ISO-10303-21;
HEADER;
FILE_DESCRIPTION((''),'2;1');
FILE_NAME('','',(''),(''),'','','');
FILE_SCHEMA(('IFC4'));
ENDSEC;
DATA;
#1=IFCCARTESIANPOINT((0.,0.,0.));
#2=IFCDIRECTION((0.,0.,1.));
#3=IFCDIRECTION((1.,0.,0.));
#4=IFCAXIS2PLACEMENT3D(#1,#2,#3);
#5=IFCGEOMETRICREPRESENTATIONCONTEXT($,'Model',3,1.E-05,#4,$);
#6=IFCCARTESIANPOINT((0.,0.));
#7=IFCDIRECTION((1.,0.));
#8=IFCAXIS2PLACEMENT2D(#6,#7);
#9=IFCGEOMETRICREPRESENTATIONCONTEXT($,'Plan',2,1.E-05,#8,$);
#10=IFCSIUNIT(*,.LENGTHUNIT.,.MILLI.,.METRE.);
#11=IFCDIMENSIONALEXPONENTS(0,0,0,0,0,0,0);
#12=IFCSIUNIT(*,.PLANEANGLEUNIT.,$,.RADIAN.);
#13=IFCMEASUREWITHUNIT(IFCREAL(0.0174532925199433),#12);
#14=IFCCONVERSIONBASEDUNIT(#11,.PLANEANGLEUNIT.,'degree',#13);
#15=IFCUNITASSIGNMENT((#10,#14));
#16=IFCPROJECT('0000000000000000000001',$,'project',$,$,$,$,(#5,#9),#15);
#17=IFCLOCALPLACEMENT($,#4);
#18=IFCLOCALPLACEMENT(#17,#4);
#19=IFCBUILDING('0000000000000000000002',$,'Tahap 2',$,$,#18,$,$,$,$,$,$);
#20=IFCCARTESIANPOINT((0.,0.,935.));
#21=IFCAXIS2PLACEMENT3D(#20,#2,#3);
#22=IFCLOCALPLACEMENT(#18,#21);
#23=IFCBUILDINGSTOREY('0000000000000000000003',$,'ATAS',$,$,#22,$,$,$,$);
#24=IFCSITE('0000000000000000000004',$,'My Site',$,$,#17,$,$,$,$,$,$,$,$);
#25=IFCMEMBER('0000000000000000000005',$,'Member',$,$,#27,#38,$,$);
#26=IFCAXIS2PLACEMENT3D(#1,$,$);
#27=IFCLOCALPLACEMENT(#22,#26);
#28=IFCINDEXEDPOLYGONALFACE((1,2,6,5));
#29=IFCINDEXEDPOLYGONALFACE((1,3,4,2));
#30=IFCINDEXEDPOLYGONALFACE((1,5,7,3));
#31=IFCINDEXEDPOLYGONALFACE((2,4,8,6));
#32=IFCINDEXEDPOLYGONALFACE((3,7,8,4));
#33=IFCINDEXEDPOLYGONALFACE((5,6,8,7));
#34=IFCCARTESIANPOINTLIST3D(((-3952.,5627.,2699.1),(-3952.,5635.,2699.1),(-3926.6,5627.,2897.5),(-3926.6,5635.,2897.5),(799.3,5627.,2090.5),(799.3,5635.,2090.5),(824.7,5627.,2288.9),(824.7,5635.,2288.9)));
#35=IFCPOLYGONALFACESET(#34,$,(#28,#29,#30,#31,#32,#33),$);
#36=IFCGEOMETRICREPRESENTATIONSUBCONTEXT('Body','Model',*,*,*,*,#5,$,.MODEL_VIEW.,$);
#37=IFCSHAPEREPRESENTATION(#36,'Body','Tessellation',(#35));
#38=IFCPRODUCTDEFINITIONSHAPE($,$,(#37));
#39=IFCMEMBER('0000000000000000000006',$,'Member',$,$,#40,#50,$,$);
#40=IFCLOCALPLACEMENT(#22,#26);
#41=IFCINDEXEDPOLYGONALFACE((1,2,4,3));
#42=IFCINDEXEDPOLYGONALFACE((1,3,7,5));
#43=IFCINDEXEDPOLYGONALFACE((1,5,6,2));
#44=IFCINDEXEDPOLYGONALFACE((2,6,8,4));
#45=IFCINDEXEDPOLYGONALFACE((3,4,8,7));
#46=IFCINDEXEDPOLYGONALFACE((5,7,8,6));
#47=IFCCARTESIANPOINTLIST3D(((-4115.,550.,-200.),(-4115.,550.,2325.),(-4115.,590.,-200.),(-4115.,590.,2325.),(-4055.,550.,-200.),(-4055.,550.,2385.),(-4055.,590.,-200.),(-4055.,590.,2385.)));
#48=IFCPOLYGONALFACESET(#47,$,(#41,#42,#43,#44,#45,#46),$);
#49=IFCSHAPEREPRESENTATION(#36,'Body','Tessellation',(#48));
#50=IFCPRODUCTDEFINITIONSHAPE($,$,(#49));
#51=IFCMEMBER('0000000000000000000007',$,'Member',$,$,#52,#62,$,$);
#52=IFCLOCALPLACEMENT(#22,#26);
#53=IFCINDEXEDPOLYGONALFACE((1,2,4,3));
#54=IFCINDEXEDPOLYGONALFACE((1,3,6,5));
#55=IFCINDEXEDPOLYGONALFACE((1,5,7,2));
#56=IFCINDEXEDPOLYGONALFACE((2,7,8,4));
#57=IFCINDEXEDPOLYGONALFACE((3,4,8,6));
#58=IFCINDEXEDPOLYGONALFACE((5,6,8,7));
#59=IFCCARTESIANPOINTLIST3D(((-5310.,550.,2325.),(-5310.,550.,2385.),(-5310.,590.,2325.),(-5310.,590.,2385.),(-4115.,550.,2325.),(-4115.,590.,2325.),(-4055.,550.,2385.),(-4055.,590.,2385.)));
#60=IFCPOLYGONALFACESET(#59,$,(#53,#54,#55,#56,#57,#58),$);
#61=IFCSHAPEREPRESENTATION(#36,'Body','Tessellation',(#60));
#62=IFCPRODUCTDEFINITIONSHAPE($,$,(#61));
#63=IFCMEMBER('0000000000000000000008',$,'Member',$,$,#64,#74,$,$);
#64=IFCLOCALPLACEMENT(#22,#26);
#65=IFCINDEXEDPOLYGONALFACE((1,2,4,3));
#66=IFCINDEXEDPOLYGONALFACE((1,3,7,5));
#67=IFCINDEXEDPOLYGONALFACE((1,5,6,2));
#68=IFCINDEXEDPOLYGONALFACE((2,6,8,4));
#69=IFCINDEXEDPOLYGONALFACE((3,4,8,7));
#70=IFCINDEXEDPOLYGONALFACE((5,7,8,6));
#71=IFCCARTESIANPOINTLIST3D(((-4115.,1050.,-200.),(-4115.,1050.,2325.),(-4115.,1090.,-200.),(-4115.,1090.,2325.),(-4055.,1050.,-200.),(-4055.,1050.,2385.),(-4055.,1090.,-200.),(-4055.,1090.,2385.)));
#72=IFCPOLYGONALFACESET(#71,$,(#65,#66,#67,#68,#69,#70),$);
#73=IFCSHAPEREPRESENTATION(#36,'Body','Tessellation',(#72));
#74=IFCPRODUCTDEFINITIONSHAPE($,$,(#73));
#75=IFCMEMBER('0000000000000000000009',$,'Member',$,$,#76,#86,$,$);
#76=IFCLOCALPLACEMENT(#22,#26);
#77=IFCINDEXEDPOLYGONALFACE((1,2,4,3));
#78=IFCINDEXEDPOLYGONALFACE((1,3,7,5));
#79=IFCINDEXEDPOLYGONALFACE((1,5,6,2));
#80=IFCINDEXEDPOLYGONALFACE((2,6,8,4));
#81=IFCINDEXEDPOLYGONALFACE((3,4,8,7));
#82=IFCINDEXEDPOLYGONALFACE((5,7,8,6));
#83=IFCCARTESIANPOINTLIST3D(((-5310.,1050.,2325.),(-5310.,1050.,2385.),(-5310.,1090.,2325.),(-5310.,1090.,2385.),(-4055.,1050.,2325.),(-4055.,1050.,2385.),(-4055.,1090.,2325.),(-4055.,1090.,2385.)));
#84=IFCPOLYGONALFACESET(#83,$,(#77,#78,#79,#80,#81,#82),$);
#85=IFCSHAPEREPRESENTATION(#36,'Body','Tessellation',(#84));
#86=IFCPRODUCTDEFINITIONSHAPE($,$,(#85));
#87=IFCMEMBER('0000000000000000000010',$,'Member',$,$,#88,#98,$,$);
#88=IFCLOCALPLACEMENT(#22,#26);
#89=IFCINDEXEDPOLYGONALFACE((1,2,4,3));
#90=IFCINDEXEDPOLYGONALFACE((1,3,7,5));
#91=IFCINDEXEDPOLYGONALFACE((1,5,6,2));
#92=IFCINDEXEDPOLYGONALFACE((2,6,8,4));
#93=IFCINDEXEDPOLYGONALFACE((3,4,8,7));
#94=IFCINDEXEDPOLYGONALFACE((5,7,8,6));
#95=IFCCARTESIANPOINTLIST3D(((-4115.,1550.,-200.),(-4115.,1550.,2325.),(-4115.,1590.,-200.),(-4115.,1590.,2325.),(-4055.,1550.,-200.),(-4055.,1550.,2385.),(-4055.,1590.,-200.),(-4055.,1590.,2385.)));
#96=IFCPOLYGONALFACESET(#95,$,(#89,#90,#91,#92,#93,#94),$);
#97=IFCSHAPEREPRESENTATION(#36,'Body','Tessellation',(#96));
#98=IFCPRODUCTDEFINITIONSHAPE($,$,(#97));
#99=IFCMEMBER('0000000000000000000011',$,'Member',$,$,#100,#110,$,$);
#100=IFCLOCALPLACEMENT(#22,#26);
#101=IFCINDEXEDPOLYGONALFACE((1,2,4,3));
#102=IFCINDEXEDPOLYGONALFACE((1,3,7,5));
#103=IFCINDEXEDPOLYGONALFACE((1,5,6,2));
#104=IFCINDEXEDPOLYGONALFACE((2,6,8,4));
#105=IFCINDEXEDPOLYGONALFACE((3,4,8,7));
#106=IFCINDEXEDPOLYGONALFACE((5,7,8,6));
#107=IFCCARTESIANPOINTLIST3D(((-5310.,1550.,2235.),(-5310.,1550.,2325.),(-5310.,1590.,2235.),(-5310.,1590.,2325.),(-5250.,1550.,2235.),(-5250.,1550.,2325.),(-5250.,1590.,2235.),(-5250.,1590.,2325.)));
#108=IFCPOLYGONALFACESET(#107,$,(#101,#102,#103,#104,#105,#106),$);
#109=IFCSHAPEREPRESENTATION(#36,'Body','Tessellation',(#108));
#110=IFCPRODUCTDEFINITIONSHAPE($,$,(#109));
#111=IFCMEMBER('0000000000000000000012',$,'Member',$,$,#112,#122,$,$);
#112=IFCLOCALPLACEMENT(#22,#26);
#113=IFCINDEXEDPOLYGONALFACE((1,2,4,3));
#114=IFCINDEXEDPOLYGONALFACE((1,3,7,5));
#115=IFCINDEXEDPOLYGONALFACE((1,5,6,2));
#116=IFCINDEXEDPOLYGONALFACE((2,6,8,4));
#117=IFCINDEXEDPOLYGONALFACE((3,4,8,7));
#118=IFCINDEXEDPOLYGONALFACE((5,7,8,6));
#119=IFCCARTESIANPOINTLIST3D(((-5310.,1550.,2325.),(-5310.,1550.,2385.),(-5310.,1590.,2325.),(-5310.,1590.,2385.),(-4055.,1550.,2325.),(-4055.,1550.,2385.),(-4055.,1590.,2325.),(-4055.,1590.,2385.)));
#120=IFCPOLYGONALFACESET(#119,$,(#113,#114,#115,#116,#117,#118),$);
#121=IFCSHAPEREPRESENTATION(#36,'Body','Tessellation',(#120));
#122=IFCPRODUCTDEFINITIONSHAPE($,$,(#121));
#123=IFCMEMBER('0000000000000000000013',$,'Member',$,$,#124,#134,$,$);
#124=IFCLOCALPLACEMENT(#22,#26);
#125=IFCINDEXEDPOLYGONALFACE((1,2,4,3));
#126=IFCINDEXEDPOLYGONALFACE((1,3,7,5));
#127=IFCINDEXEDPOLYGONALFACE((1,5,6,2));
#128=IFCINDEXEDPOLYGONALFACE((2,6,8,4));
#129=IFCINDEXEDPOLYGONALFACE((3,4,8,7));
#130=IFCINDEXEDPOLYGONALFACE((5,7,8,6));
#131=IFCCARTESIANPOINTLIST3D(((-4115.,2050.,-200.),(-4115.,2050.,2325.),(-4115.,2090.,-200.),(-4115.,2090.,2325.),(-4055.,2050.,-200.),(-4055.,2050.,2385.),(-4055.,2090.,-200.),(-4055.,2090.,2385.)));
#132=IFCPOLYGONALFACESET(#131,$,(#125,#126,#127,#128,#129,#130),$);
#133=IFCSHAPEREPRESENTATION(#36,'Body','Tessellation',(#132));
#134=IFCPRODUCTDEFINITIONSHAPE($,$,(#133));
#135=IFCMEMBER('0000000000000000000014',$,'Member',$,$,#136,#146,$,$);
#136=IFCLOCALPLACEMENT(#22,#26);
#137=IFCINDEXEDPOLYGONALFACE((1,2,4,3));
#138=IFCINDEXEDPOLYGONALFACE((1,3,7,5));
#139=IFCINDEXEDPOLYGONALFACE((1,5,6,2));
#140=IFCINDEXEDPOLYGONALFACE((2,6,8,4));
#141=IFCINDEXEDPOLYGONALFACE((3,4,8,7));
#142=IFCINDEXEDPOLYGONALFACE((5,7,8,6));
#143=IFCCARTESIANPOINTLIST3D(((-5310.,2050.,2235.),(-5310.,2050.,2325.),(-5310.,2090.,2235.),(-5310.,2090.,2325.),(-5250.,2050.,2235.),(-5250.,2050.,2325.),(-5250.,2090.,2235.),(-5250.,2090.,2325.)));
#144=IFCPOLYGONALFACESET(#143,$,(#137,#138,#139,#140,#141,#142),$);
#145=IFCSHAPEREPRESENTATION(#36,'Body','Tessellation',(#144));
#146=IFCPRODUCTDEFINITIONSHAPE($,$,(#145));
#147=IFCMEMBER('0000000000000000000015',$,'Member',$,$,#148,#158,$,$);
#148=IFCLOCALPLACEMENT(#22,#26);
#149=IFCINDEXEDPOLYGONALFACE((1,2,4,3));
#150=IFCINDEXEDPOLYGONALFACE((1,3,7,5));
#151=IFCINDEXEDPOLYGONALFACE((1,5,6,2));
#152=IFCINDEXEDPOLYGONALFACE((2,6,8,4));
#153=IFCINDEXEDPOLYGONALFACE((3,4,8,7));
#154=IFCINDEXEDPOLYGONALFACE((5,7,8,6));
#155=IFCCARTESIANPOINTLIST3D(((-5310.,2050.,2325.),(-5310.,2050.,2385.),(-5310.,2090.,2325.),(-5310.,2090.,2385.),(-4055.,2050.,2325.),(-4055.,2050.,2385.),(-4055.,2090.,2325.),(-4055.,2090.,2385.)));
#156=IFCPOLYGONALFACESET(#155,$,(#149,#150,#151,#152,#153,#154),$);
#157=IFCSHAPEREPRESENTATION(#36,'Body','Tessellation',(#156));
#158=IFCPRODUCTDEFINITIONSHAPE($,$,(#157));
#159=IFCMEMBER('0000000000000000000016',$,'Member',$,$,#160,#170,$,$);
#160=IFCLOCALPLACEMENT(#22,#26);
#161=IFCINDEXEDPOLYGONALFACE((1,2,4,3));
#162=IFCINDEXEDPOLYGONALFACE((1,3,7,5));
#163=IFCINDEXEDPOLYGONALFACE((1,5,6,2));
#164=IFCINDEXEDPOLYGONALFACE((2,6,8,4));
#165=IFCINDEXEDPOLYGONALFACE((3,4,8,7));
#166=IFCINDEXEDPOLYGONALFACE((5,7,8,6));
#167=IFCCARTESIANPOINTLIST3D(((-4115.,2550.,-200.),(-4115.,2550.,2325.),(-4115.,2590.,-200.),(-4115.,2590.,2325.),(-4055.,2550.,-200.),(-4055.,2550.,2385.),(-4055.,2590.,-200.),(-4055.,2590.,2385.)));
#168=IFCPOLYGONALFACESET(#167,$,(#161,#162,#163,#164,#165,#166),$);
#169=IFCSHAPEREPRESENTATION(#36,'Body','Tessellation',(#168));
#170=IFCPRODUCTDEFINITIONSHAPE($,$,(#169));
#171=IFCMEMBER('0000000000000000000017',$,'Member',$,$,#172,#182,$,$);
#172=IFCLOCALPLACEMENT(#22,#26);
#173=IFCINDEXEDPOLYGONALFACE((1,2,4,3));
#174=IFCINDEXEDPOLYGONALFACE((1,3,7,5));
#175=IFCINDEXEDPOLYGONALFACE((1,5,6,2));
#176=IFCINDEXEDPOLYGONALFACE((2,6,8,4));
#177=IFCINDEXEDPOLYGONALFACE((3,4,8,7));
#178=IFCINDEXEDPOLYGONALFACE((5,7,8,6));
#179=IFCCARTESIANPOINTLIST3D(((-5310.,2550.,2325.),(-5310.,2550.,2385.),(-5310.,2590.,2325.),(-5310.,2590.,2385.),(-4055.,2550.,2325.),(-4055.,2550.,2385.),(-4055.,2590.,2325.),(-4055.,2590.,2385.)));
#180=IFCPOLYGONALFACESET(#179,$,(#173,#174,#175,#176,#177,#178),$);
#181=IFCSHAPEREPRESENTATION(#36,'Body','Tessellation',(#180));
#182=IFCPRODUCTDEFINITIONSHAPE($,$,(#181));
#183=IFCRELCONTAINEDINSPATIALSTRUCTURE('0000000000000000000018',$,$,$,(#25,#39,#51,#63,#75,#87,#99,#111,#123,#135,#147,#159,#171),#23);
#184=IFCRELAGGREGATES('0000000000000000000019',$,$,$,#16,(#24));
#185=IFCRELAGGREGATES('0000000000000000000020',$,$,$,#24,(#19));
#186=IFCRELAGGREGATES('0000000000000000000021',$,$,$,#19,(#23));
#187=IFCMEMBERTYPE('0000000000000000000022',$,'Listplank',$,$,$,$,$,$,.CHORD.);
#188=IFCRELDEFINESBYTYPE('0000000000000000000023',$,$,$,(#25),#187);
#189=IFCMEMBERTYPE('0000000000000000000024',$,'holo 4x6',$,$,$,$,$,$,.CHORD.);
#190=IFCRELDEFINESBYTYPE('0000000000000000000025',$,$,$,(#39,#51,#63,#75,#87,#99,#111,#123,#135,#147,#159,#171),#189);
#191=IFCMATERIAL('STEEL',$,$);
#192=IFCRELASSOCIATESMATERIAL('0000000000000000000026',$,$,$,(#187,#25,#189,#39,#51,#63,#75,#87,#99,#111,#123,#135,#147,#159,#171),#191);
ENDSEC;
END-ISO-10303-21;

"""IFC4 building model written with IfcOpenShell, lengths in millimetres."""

from ifc_helpers import new_model, entity, si_unit, converted_unit, frame, origin_with_axes, origin_2d_with_axis, place, context, subcontext, project, spatial, rectangle, extrude, clip, halfspace, material, material_profile, profile_set, profile_usage, type_object, element, save


model = new_model("IFC4")

# Units and contexts
model_context = context("Model", 3, precision=1e-05, world=origin_with_axes())
plan_context = context("Plan", 2, precision=1e-05, world=origin_2d_with_axis())
body_context = subcontext(model_context, "Body", "Model", "MODEL_VIEW")
ifc_project = project(units=[si_unit("LENGTHUNIT", "METRE", prefix="MILLI"), converted_unit("PLANEANGLEUNIT", "degree", entity("IfcReal", 0.0174532925199433), si_unit("PLANEANGLEUNIT", "RADIAN"), dimensions=[0, 0, 0, 0, 0, 0, 0])], contexts=[model_context, plan_context])

# Site, building, storey
site_placement = place(None, origin_with_axes())
site = spatial("IfcSite", under=ifc_project, at=site_placement, Name="My Site")
building_placement = place(site_placement, origin_with_axes())
building = spatial("IfcBuilding", under=site, at=building_placement, Name="Tahap 2")
storey_placement = place(building_placement, frame((0.0, 0.0, 935.0), z_axis=(0.0, 0.0, 1.0), x_axis=(1.0, 0.0, 0.0)))
storey = spatial("IfcBuildingStorey", under=building, at=storey_placement, Name="ATAS")

# Members
ifc_material_1 = material(Name="STEEL")
ifc_material_profile_1 = material_profile(ifc_material_1, rectangle(XDim=8.0, YDim=200.0, kind="CURVE"))
ifc_profile_set_1 = profile_set([ifc_material_profile_1])
ifc_profile_usage_1 = profile_usage(ifc_profile_set_1, cardinal=9)
member_type_1 = type_object("IfcMemberType", Name="Listplank", PredefinedType="CHORD", material=ifc_profile_set_1)
member_1_placement = place(storey_placement, frame((824.7, 5635.0, 2288.9), z_axis=(-0.991894, 0.0, 0.127064), x_axis=(0.0, -1.0, 0.0)))
element("IfcMember", 1, at=member_1_placement, inside=storey, type_object=member_type_1, material=ifc_profile_usage_1, Name="Member", context=body_context, shape_type="SweptSolid", body=[
    extrude(rectangle(XDim=8.0, YDim=200.0, kind="CURVE"), frame((4.0, -100.0, 0.0), z_axis=(0.0, 0.0, 1.0), x_axis=(1.0, 0.0, 0.0)), (0.0, 0.0, 1.0), 4790.2),
])
ifc_material_profile_2 = material_profile(ifc_material_1, rectangle(XDim=40.0, YDim=60.0, kind="CURVE"))
ifc_profile_set_2 = profile_set([ifc_material_profile_2])
ifc_profile_usage_2 = profile_usage(ifc_profile_set_2, cardinal=8)
member_type_2 = type_object("IfcMemberType", Name="holo 4x6", PredefinedType="CHORD", material=ifc_profile_set_2)
member_2_placement = place(storey_placement, frame((-4055.0, 570.0, -200.0), z_axis=(0.0, 0.0, 1.0), x_axis=(0.0, -1.0, 0.0)))
element("IfcMember", 2, at=member_2_placement, inside=storey, type_object=member_type_2, material=ifc_profile_usage_2, Name="Member", context=body_context, shape_type="Clipping", body=[
    clip(extrude(rectangle(XDim=40.0, YDim=60.0, kind="CURVE"), frame((0.0, -30.0, 0.0), z_axis=(0.0, 0.0, 1.0), x_axis=(1.0, 0.0, 0.0)), (0.0, 0.0, 1.0), 2585.0), halfspace(frame((550.0, 0.0, 2585.0), z_axis=(0.0, -0.707107, 0.707107), x_axis=(-1.0, 0.0, 0.0)), False)),
])
ifc_profile_usage_3 = profile_usage(ifc_profile_set_2, cardinal=8)
member_3_placement = place(storey_placement, frame((-4055.0, 570.0, 2385.0), z_axis=(-1.0, 0.0, 0.0), x_axis=(0.0, -1.0, 0.0)))
element("IfcMember", 3, at=member_3_placement, inside=storey, type_object=member_type_2, material=ifc_profile_usage_3, Name="Member", context=body_context, shape_type="Clipping", body=[
    clip(extrude(rectangle(XDim=40.0, YDim=60.0, kind="CURVE"), frame((0.0, -30.0, 0.0), z_axis=(0.0, 0.0, 1.0), x_axis=(1.0, 0.0, 0.0)), (0.0, 0.0, 1.0), 1255.0), halfspace(frame((570.0, 0.0, 0.0), z_axis=(0.0, -0.707107, -0.707107), x_axis=(-1.0, 0.0, 0.0)), False)),
])
ifc_profile_usage_4 = profile_usage(ifc_profile_set_2, cardinal=8)
member_4_placement = place(storey_placement, frame((-4055.0, 1070.0, -200.0), z_axis=(0.0, 0.0, 1.0), x_axis=(0.0, -1.0, 0.0)))
element("IfcMember", 4, at=member_4_placement, inside=storey, type_object=member_type_2, material=ifc_profile_usage_4, Name="Member", context=body_context, shape_type="Clipping", body=[
    clip(extrude(rectangle(XDim=40.0, YDim=60.0, kind="CURVE"), frame((0.0, -30.0, 0.0), z_axis=(0.0, 0.0, 1.0), x_axis=(1.0, 0.0, 0.0)), (0.0, 0.0, 1.0), 2585.0), halfspace(frame((550.0, 0.0, 2585.0), z_axis=(0.0, -0.707107, 0.707107), x_axis=(-1.0, 0.0, 0.0)), False)),
])
ifc_profile_usage_5 = profile_usage(ifc_profile_set_2, cardinal=8)
member_5_placement = place(storey_placement, frame((-4055.0, 1070.0, 2385.0), z_axis=(-1.0, 0.0, 0.0), x_axis=(0.0, -1.0, 0.0)))
element("IfcMember", 5, at=member_5_placement, inside=storey, type_object=member_type_2, material=ifc_profile_usage_5, Name="Member", context=body_context, shape_type="SweptSolid", body=[
    extrude(rectangle(XDim=40.0, YDim=60.0, kind="CURVE"), frame((0.0, -30.0, 0.0), z_axis=(0.0, 0.0, 1.0), x_axis=(1.0, 0.0, 0.0)), (0.0, 0.0, 1.0), 1255.0),
])
ifc_profile_usage_6 = profile_usage(ifc_profile_set_2, cardinal=8)
member_6_placement = place(storey_placement, frame((-4055.0, 1570.0, -200.0), z_axis=(0.0, 0.0, 1.0), x_axis=(0.0, -1.0, 0.0)))
element("IfcMember", 6, at=member_6_placement, inside=storey, type_object=member_type_2, material=ifc_profile_usage_6, Name="Member", context=body_context, shape_type="Clipping", body=[
    clip(extrude(rectangle(XDim=40.0, YDim=60.0, kind="CURVE"), frame((0.0, -30.0, 0.0), z_axis=(0.0, 0.0, 1.0), x_axis=(1.0, 0.0, 0.0)), (0.0, 0.0, 1.0), 2585.0), halfspace(frame((550.0, 0.0, 2585.0), z_axis=(0.0, -0.707107, 0.707107), x_axis=(-1.0, 0.0, 0.0)), False)),
])
ifc_profile_usage_7 = profile_usage(ifc_profile_set_2, cardinal=8)
member_7_placement = place(storey_placement, frame((-5250.0, 1570.0, 2235.0), z_axis=(0.0, 0.0, 1.0), x_axis=(0.0, -1.0, 0.0)))
element("IfcMember", 7, at=member_7_placement, inside=storey, type_object=member_type_2, material=ifc_profile_usage_7, Name="Member", context=body_context, shape_type="SweptSolid", body=[
    extrude(rectangle(XDim=40.0, YDim=60.0, kind="CURVE"), frame((0.0, -30.0, 0.0), z_axis=(0.0, 0.0, 1.0), x_axis=(1.0, 0.0, 0.0)), (0.0, 0.0, 1.0), 90.0),
])
ifc_profile_usage_8 = profile_usage(ifc_profile_set_2, cardinal=8)
member_8_placement = place(storey_placement, frame((-4055.0, 1570.0, 2385.0), z_axis=(-1.0, 0.0, 0.0), x_axis=(0.0, -1.0, 0.0)))
element("IfcMember", 8, at=member_8_placement, inside=storey, type_object=member_type_2, material=ifc_profile_usage_8, Name="Member", context=body_context, shape_type="SweptSolid", body=[
    extrude(rectangle(XDim=40.0, YDim=60.0, kind="CURVE"), frame((0.0, -30.0, 0.0), z_axis=(0.0, 0.0, 1.0), x_axis=(1.0, 0.0, 0.0)), (0.0, 0.0, 1.0), 1255.0),
])
ifc_profile_usage_9 = profile_usage(ifc_profile_set_2, cardinal=8)
member_9_placement = place(storey_placement, frame((-4055.0, 2070.0, -200.0), z_axis=(0.0, 0.0, 1.0), x_axis=(0.0, -1.0, 0.0)))
element("IfcMember", 9, at=member_9_placement, inside=storey, type_object=member_type_2, material=ifc_profile_usage_9, Name="Member", context=body_context, shape_type="Clipping", body=[
    clip(extrude(rectangle(XDim=40.0, YDim=60.0, kind="CURVE"), frame((0.0, -30.0, 0.0), z_axis=(0.0, 0.0, 1.0), x_axis=(1.0, 0.0, 0.0)), (0.0, 0.0, 1.0), 2585.0), halfspace(frame((550.0, 0.0, 2585.0), z_axis=(0.0, -0.707107, 0.707107), x_axis=(-1.0, 0.0, 0.0)), False)),
])
ifc_profile_usage_10 = profile_usage(ifc_profile_set_2, cardinal=8)
member_10_placement = place(storey_placement, frame((-5250.0, 2070.0, 2235.0), z_axis=(0.0, 0.0, 1.0), x_axis=(0.0, -1.0, 0.0)))
element("IfcMember", 10, at=member_10_placement, inside=storey, type_object=member_type_2, material=ifc_profile_usage_10, Name="Member", context=body_context, shape_type="SweptSolid", body=[
    extrude(rectangle(XDim=40.0, YDim=60.0, kind="CURVE"), frame((0.0, -30.0, 0.0), z_axis=(0.0, 0.0, 1.0), x_axis=(1.0, 0.0, 0.0)), (0.0, 0.0, 1.0), 90.0),
])
ifc_profile_usage_11 = profile_usage(ifc_profile_set_2, cardinal=8)
member_11_placement = place(storey_placement, frame((-4055.0, 2070.0, 2385.0), z_axis=(-1.0, 0.0, 0.0), x_axis=(0.0, -1.0, 0.0)))
element("IfcMember", 11, at=member_11_placement, inside=storey, type_object=member_type_2, material=ifc_profile_usage_11, Name="Member", context=body_context, shape_type="SweptSolid", body=[
    extrude(rectangle(XDim=40.0, YDim=60.0, kind="CURVE"), frame((0.0, -30.0, 0.0), z_axis=(0.0, 0.0, 1.0), x_axis=(1.0, 0.0, 0.0)), (0.0, 0.0, 1.0), 1255.0),
])
ifc_profile_usage_12 = profile_usage(ifc_profile_set_2, cardinal=8)
member_12_placement = place(storey_placement, frame((-4055.0, 2570.0, -200.0), z_axis=(0.0, 0.0, 1.0), x_axis=(0.0, -1.0, 0.0)))
element("IfcMember", 12, at=member_12_placement, inside=storey, type_object=member_type_2, material=ifc_profile_usage_12, Name="Member", context=body_context, shape_type="Clipping", body=[
    clip(extrude(rectangle(XDim=40.0, YDim=60.0, kind="CURVE"), frame((0.0, -30.0, 0.0), z_axis=(0.0, 0.0, 1.0), x_axis=(1.0, 0.0, 0.0)), (0.0, 0.0, 1.0), 2585.0), halfspace(frame((550.0, 0.0, 2585.0), z_axis=(0.0, -0.707107, 0.707107), x_axis=(-1.0, 0.0, 0.0)), False)),
])
ifc_profile_usage_13 = profile_usage(ifc_profile_set_2, cardinal=8)
member_13_placement = place(storey_placement, frame((-4055.0, 2570.0, 2385.0), z_axis=(-1.0, 0.0, 0.0), x_axis=(0.0, -1.0, 0.0)))
element("IfcMember", 13, at=member_13_placement, inside=storey, type_object=member_type_2, material=ifc_profile_usage_13, Name="Member", context=body_context, shape_type="SweptSolid", body=[
    extrude(rectangle(XDim=40.0, YDim=60.0, kind="CURVE"), frame((0.0, -30.0, 0.0), z_axis=(0.0, 0.0, 1.0), x_axis=(1.0, 0.0, 0.0)), (0.0, 0.0, 1.0), 1255.0),
])

save(model, "model.ifc")
